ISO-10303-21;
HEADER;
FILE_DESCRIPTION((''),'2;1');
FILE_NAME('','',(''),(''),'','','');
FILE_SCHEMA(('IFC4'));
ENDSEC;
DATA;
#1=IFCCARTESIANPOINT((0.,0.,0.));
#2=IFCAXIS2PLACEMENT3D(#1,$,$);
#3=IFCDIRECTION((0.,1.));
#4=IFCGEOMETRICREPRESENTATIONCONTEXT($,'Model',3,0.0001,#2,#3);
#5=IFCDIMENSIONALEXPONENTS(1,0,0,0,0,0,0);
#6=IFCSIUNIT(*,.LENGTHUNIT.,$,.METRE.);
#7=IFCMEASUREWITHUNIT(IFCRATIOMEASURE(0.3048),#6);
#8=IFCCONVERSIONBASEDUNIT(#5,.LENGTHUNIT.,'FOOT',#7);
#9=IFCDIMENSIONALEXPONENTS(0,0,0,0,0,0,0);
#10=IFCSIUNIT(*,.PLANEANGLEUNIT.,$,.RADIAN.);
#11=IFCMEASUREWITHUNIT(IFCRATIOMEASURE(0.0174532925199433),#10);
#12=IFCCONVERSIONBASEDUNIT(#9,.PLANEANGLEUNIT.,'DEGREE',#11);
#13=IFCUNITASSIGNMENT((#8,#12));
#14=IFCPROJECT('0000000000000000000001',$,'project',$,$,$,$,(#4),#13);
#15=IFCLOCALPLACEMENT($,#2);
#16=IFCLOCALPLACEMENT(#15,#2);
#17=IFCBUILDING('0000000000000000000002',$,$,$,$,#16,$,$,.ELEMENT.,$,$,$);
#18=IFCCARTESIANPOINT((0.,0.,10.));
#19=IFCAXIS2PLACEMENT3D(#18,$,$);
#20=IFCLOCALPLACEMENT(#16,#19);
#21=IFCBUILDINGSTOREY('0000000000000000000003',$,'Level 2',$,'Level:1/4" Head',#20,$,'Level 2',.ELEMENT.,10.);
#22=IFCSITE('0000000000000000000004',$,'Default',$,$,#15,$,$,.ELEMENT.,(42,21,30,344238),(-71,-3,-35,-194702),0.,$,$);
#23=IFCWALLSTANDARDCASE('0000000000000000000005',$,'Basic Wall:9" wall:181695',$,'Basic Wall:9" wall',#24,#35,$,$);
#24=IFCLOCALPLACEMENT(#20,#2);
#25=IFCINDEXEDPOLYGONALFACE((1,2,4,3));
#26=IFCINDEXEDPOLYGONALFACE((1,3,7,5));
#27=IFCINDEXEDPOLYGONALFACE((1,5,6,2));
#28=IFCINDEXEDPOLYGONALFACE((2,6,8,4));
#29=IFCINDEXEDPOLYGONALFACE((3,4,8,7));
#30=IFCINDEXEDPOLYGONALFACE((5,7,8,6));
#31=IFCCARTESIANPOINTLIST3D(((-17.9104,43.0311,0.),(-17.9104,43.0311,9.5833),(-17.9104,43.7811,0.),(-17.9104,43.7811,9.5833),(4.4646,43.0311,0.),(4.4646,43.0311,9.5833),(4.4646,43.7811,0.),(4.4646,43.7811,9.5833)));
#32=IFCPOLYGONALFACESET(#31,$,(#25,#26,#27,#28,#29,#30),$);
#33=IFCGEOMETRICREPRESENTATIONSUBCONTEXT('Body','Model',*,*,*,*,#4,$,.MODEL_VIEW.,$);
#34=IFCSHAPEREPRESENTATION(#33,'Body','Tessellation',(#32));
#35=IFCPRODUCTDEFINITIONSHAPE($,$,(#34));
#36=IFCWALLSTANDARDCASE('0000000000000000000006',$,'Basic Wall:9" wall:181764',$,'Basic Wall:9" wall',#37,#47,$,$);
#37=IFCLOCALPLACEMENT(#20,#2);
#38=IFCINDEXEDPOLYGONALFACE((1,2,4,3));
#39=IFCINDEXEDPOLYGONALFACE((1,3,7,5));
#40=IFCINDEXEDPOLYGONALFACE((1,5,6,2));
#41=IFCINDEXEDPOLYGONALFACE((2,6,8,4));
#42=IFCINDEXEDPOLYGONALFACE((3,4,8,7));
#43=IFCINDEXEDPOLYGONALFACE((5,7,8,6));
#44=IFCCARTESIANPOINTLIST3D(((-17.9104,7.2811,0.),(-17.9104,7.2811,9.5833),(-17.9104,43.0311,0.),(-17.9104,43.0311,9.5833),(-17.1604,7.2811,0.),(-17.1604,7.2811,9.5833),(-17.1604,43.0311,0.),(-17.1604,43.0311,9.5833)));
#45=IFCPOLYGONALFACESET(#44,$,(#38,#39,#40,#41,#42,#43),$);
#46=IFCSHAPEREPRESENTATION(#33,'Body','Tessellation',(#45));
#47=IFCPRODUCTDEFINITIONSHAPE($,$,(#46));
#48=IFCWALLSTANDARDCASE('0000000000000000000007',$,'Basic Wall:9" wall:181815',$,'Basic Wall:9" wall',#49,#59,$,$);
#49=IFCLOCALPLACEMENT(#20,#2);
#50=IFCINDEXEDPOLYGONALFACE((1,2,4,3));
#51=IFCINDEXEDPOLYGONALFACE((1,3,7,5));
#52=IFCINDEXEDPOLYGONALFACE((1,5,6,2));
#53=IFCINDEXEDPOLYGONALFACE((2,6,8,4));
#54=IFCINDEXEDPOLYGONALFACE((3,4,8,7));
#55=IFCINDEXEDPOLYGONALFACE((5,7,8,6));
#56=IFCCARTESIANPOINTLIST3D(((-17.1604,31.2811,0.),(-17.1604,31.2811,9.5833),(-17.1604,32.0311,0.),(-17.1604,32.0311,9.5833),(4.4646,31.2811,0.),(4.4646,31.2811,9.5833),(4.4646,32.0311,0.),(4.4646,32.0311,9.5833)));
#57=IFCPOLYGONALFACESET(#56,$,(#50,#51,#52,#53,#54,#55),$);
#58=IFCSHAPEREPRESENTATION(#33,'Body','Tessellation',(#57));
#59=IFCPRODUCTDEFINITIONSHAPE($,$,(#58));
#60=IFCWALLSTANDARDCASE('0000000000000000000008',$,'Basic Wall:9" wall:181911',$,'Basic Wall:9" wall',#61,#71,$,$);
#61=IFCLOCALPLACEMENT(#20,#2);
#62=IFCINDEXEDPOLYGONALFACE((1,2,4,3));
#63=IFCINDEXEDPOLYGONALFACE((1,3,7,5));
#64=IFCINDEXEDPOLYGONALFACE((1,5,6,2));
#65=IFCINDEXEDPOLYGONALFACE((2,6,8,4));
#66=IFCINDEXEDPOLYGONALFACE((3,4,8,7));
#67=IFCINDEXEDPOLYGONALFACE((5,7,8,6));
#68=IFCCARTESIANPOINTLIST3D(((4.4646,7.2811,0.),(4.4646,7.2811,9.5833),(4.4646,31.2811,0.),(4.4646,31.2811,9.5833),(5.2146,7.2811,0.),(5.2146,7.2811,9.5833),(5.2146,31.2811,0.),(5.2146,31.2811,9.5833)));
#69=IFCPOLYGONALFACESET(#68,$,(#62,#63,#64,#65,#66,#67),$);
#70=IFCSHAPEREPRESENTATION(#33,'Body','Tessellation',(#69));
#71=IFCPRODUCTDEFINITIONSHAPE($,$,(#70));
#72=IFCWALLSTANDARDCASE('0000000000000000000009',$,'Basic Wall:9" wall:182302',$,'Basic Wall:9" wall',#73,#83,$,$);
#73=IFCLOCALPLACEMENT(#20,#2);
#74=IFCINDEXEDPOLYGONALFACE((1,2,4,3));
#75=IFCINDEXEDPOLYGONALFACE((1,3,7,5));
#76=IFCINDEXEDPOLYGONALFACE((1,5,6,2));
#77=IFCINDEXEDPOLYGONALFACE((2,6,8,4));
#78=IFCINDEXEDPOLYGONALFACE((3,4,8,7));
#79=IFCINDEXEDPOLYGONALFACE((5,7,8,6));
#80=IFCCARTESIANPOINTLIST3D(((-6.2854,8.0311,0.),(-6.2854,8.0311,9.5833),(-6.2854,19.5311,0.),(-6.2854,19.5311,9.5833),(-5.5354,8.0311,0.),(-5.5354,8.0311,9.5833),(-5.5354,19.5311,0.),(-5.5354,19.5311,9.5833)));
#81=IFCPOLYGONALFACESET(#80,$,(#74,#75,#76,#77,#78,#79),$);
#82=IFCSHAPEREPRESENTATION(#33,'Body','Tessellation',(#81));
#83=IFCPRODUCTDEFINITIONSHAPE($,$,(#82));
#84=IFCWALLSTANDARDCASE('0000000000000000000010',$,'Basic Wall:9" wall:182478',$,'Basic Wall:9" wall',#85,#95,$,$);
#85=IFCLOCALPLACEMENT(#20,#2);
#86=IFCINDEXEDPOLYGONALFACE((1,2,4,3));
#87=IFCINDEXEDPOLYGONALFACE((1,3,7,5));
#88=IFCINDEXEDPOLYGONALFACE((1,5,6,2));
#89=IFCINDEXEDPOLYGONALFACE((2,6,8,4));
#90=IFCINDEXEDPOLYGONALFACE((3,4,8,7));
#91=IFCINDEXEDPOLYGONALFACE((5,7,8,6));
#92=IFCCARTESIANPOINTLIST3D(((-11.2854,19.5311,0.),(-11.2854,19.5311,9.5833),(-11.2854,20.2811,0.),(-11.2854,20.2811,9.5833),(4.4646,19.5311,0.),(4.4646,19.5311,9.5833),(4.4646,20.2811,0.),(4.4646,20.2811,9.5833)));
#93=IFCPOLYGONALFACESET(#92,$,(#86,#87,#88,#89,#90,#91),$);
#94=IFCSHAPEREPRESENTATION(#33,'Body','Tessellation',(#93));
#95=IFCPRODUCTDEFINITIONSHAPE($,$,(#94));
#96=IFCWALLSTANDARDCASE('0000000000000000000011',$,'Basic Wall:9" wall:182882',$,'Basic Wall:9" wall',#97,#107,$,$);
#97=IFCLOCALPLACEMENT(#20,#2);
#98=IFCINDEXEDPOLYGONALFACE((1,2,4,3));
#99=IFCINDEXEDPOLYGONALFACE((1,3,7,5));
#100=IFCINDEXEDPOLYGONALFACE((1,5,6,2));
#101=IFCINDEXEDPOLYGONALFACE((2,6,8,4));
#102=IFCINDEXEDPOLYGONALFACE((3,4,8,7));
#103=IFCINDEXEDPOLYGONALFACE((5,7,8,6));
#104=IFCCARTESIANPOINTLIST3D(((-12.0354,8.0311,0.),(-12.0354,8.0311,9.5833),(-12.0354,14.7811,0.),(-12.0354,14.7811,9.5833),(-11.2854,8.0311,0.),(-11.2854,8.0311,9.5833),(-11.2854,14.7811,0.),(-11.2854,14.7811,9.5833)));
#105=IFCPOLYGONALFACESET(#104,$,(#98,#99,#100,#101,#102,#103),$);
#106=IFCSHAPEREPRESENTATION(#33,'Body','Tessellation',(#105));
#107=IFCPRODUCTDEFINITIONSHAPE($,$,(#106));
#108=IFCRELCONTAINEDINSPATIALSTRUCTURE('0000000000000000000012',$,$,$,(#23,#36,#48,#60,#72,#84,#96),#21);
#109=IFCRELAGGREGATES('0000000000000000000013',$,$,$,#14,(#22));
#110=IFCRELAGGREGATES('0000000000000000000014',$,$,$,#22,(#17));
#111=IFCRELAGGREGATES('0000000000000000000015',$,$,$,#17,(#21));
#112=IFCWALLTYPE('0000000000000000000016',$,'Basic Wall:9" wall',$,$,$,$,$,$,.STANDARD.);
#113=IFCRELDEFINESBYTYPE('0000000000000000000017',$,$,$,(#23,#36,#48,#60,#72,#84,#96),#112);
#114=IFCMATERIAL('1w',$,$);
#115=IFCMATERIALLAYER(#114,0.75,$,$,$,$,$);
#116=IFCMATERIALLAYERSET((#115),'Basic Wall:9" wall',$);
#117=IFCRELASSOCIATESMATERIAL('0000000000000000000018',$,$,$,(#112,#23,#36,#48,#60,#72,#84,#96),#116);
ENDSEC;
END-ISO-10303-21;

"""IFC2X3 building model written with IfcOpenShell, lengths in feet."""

from ifc_helpers import new_model, entity, si_unit, converted_unit, direction, frame, frame_2d, origin, place, context, subcontext, project, spatial, polyline, rectangle, extrude, clip, bounded_halfspace, material, layer, layer_set, layer_usage, type_object, element, save


model = new_model("IFC2X3")

# Units and contexts
model_context = context("Model", 3, precision=0.0001, world=origin(), true_north=direction((0.0, 1.0)))
body_context = subcontext(model_context, "Body", "Model", "MODEL_VIEW")
ifc_project = project(units=[converted_unit("LENGTHUNIT", "FOOT", entity("IfcRatioMeasure", 0.3048), si_unit("LENGTHUNIT", "METRE"), dimensions=[1, 0, 0, 0, 0, 0, 0]), converted_unit("PLANEANGLEUNIT", "DEGREE", entity("IfcRatioMeasure", 0.0174532925199433), si_unit("PLANEANGLEUNIT", "RADIAN"), dimensions=[0, 0, 0, 0, 0, 0, 0])], contexts=[model_context])

# Site, building, storey
site_placement = place(None, origin())
site = spatial("IfcSite", under=ifc_project, at=site_placement, Name="Default", CompositionType="ELEMENT", RefLatitude=(42, 21, 30, 344238), RefLongitude=(-71, -3, -35, -194702), RefElevation=0.0)
building_placement = place(site_placement, origin())
building = spatial("IfcBuilding", under=site, at=building_placement, CompositionType="ELEMENT")
storey_placement = place(building_placement, frame((0.0, 0.0, 10.0)))
storey = spatial("IfcBuildingStorey", under=building, at=storey_placement, Name="Level 2", ObjectType="Level:1/4\" Head", LongName="Level 2", CompositionType="ELEMENT", Elevation=10.0)

# Shared definitions
ifc_material_1 = material(Name="1w")

# Walls
ifc_layer_1 = layer(ifc_material_1, 0.75)
ifc_layer_set_1 = layer_set([ifc_layer_1], Name="Basic Wall:9\" wall")
wall_type = type_object("IfcWallType", Name="Basic Wall:9\" wall", PredefinedType="STANDARD", material=ifc_layer_set_1)
ifc_layer_usage_1 = layer_usage(ifc_layer_set_1, "AXIS2", "NEGATIVE", 0.375)
wall_1_placement = place(storey_placement, frame((4.4646, 43.4061, 0.0), z_axis=(0.0, 0.0, 1.0), x_axis=(-1.0, 0.0, 0.0)))
element("IfcWallStandardCase", 1, at=wall_1_placement, inside=storey, type_object=wall_type, material=ifc_layer_usage_1, Name="Basic Wall:9\" wall:181695", ObjectType="Basic Wall:9\" wall", context=body_context, shape_type="Clipping", body=[
    clip(extrude(rectangle(XDim=22.375, YDim=0.75, at=frame_2d((11.1875, 0.0), x_axis=(-1.0, 0.0))), origin(), (0.0, 0.0, 1.0), 9.5833), bounded_halfspace(frame((0.0, -0.375, 9.5833), z_axis=(0.0, 0.0, -1.0), x_axis=(0.0, 1.0, 0.0)), True, frame((0.0, -0.375, 9.5833)), polyline([(0.0, 0.0), (22.375, 0.0), (22.375, 0.75), (21.625, 0.75), (10.875, 0.75), (6.875, 0.75), (0.0, 0.75), (0.0, 0.0)]))),
])
ifc_layer_usage_2 = layer_usage(ifc_layer_set_1, "AXIS2", "NEGATIVE", 0.375)
wall_2_placement = place(storey_placement, frame((-17.5354, 43.0311, 0.0), z_axis=(0.0, 0.0, 1.0), x_axis=(0.0, -1.0, 0.0)))
element("IfcWallStandardCase", 2, at=wall_2_placement, inside=storey, type_object=wall_type, material=ifc_layer_usage_2, Name="Basic Wall:9\" wall:181764", ObjectType="Basic Wall:9\" wall", context=body_context, shape_type="Clipping", body=[
    clip(extrude(rectangle(XDim=35.75, YDim=0.75, at=frame_2d((17.875, 0.0), x_axis=(-1.0, 0.0))), origin(), (0.0, 0.0, 1.0), 9.5833), bounded_halfspace(frame((0.0, -0.375, 9.5833), z_axis=(0.0, 0.0, -1.0), x_axis=(1.0, 0.0, 0.0)), True, frame((0.0, -0.375, 9.5833)), polyline([(0.0, 0.0), (35.75, 0.0), (35.75, 0.75), (11.75, 0.75), (11.0, 0.75), (0.0, 0.75), (0.0, 0.0)]))),
])
ifc_layer_usage_3 = layer_usage(ifc_layer_set_1, "AXIS2", "NEGATIVE", 0.375)
wall_3_placement = place(storey_placement, frame((-17.1604, 31.6561, 0.0)))
element("IfcWallStandardCase", 3, at=wall_3_placement, inside=storey, type_object=wall_type, material=ifc_layer_usage_3, Name="Basic Wall:9\" wall:181815", ObjectType="Basic Wall:9\" wall", context=body_context, shape_type="Clipping", body=[
    clip(extrude(rectangle(XDim=21.625, YDim=0.75, at=frame_2d((10.8125, 0.0), x_axis=(-1.0, 0.0))), origin(), (0.0, 0.0, 1.0), 9.5833), bounded_halfspace(frame((0.0, -0.375, 9.5833), z_axis=(0.0, 0.0, -1.0), x_axis=(0.0, -1.0, 0.0)), True, frame((0.0, -0.375, 9.5833)), polyline([(0.0, 0.0), (5.125, 0.0), (5.875, 0.0), (21.625, 0.0), (21.625, 0.75), (0.0, 0.75), (0.0, 0.0)]))),
])
ifc_layer_usage_4 = layer_usage(ifc_layer_set_1, "AXIS2", "NEGATIVE", 0.375)
wall_4_placement = place(storey_placement, frame((4.8396, 31.2811, 0.0), z_axis=(0.0, 0.0, 1.0), x_axis=(0.0, -1.0, 0.0)))
element("IfcWallStandardCase", 4, at=wall_4_placement, inside=storey, type_object=wall_type, material=ifc_layer_usage_4, Name="Basic Wall:9\" wall:181911", ObjectType="Basic Wall:9\" wall", context=body_context, shape_type="Clipping", body=[
    clip(extrude(rectangle(XDim=24.0, YDim=0.75, at=frame_2d((12.0, 0.0), x_axis=(-1.0, 0.0))), origin(), (0.0, 0.0, 1.0), 9.5833), bounded_halfspace(frame((0.0, -0.375, 9.5833), z_axis=(0.0, 0.0, -1.0), x_axis=(1.0, 0.0, 0.0)), True, frame((0.0, -0.375, 9.5833)), polyline([(0.0, 0.0), (11.0, 0.0), (11.75, 0.0), (23.25, 0.0), (24.0, 0.0), (24.0, 0.75), (0.0, 0.75), (0.0, 0.0)]))),
])

# Walls
ifc_layer_usage_5 = layer_usage(ifc_layer_set_1, "AXIS2", "POSITIVE", -0.375)
wall_5_placement = place(storey_placement, frame((-5.9104, 8.0311, 0.0), z_axis=(0.0, 0.0, 1.0), x_axis=(0.0, 1.0, 0.0)))
element("IfcWallStandardCase", 5, at=wall_5_placement, inside=storey, type_object=wall_type, material=ifc_layer_usage_5, Name="Basic Wall:9\" wall:182302", ObjectType="Basic Wall:9\" wall", context=body_context, shape_type="Clipping", body=[
    clip(extrude(rectangle(XDim=11.5, YDim=0.75, at=frame_2d((5.75, 0.0), x_axis=(-1.0, 0.0))), origin(), (0.0, 0.0, 1.0), 9.5833), bounded_halfspace(frame((0.0, -0.375, 9.5833), z_axis=(0.0, 0.0, -1.0), x_axis=(-1.0, 0.0, 0.0)), True, frame((0.0, -0.375, 9.5833)), polyline([(0.0, 0.0), (11.5, 0.0), (11.5, 0.75), (6.75, 0.75), (6.0, 0.75), (0.0, 0.75), (0.0, 0.0)]))),
])
ifc_layer_usage_6 = layer_usage(ifc_layer_set_1, "AXIS2", "NEGATIVE", 0.375)
wall_6_placement = place(storey_placement, frame((4.4646, 19.9061, 0.0), z_axis=(0.0, 0.0, 1.0), x_axis=(-1.0, 0.0, 0.0)))
element("IfcWallStandardCase", 6, at=wall_6_placement, inside=storey, type_object=wall_type, material=ifc_layer_usage_6, Name="Basic Wall:9\" wall:182478", ObjectType="Basic Wall:9\" wall", context=body_context, shape_type="Clipping", body=[
    clip(extrude(rectangle(XDim=15.75, YDim=0.75, at=frame_2d((7.875, 0.0), x_axis=(-1.0, 0.0))), origin(), (0.0, 0.0, 1.0), 9.5833), bounded_halfspace(frame((0.0, -0.375, 9.5833), z_axis=(0.0, 0.0, -1.0), x_axis=(0.0, 1.0, 0.0)), True, frame((0.0, -0.375, 9.5833)), polyline([(0.0, 0.0), (15.75, 0.0), (15.75, 0.75), (10.75, 0.75), (10.0, 0.75), (0.0, 0.75), (0.0, 0.0)]))),
])

# Wall
ifc_layer_usage_7 = layer_usage(ifc_layer_set_1, "AXIS2", "POSITIVE", -0.375)
wall_7_placement = place(storey_placement, frame((-11.6604, 8.0311, 0.0), z_axis=(0.0, 0.0, 1.0), x_axis=(0.0, 1.0, 0.0)))
element("IfcWallStandardCase", 7, at=wall_7_placement, inside=storey, type_object=wall_type, material=ifc_layer_usage_7, Name="Basic Wall:9\" wall:182882", ObjectType="Basic Wall:9\" wall", context=body_context, shape_type="Clipping", body=[
    clip(extrude(rectangle(XDim=6.75, YDim=0.75, at=frame_2d((3.375, 0.0), x_axis=(-1.0, 0.0))), origin(), (0.0, 0.0, 1.0), 9.5833), bounded_halfspace(frame((0.0, -0.375, 9.5833), z_axis=(0.0, 0.0, -1.0), x_axis=(-1.0, 0.0, 0.0)), True, frame((0.0, -0.375, 9.5833)), polyline([(0.0, 0.0), (6.0, 0.0), (6.75, 0.0), (6.75, 0.75), (0.0, 0.75), (0.0, 0.0)]))),
])

save(model, "model.ifc")
